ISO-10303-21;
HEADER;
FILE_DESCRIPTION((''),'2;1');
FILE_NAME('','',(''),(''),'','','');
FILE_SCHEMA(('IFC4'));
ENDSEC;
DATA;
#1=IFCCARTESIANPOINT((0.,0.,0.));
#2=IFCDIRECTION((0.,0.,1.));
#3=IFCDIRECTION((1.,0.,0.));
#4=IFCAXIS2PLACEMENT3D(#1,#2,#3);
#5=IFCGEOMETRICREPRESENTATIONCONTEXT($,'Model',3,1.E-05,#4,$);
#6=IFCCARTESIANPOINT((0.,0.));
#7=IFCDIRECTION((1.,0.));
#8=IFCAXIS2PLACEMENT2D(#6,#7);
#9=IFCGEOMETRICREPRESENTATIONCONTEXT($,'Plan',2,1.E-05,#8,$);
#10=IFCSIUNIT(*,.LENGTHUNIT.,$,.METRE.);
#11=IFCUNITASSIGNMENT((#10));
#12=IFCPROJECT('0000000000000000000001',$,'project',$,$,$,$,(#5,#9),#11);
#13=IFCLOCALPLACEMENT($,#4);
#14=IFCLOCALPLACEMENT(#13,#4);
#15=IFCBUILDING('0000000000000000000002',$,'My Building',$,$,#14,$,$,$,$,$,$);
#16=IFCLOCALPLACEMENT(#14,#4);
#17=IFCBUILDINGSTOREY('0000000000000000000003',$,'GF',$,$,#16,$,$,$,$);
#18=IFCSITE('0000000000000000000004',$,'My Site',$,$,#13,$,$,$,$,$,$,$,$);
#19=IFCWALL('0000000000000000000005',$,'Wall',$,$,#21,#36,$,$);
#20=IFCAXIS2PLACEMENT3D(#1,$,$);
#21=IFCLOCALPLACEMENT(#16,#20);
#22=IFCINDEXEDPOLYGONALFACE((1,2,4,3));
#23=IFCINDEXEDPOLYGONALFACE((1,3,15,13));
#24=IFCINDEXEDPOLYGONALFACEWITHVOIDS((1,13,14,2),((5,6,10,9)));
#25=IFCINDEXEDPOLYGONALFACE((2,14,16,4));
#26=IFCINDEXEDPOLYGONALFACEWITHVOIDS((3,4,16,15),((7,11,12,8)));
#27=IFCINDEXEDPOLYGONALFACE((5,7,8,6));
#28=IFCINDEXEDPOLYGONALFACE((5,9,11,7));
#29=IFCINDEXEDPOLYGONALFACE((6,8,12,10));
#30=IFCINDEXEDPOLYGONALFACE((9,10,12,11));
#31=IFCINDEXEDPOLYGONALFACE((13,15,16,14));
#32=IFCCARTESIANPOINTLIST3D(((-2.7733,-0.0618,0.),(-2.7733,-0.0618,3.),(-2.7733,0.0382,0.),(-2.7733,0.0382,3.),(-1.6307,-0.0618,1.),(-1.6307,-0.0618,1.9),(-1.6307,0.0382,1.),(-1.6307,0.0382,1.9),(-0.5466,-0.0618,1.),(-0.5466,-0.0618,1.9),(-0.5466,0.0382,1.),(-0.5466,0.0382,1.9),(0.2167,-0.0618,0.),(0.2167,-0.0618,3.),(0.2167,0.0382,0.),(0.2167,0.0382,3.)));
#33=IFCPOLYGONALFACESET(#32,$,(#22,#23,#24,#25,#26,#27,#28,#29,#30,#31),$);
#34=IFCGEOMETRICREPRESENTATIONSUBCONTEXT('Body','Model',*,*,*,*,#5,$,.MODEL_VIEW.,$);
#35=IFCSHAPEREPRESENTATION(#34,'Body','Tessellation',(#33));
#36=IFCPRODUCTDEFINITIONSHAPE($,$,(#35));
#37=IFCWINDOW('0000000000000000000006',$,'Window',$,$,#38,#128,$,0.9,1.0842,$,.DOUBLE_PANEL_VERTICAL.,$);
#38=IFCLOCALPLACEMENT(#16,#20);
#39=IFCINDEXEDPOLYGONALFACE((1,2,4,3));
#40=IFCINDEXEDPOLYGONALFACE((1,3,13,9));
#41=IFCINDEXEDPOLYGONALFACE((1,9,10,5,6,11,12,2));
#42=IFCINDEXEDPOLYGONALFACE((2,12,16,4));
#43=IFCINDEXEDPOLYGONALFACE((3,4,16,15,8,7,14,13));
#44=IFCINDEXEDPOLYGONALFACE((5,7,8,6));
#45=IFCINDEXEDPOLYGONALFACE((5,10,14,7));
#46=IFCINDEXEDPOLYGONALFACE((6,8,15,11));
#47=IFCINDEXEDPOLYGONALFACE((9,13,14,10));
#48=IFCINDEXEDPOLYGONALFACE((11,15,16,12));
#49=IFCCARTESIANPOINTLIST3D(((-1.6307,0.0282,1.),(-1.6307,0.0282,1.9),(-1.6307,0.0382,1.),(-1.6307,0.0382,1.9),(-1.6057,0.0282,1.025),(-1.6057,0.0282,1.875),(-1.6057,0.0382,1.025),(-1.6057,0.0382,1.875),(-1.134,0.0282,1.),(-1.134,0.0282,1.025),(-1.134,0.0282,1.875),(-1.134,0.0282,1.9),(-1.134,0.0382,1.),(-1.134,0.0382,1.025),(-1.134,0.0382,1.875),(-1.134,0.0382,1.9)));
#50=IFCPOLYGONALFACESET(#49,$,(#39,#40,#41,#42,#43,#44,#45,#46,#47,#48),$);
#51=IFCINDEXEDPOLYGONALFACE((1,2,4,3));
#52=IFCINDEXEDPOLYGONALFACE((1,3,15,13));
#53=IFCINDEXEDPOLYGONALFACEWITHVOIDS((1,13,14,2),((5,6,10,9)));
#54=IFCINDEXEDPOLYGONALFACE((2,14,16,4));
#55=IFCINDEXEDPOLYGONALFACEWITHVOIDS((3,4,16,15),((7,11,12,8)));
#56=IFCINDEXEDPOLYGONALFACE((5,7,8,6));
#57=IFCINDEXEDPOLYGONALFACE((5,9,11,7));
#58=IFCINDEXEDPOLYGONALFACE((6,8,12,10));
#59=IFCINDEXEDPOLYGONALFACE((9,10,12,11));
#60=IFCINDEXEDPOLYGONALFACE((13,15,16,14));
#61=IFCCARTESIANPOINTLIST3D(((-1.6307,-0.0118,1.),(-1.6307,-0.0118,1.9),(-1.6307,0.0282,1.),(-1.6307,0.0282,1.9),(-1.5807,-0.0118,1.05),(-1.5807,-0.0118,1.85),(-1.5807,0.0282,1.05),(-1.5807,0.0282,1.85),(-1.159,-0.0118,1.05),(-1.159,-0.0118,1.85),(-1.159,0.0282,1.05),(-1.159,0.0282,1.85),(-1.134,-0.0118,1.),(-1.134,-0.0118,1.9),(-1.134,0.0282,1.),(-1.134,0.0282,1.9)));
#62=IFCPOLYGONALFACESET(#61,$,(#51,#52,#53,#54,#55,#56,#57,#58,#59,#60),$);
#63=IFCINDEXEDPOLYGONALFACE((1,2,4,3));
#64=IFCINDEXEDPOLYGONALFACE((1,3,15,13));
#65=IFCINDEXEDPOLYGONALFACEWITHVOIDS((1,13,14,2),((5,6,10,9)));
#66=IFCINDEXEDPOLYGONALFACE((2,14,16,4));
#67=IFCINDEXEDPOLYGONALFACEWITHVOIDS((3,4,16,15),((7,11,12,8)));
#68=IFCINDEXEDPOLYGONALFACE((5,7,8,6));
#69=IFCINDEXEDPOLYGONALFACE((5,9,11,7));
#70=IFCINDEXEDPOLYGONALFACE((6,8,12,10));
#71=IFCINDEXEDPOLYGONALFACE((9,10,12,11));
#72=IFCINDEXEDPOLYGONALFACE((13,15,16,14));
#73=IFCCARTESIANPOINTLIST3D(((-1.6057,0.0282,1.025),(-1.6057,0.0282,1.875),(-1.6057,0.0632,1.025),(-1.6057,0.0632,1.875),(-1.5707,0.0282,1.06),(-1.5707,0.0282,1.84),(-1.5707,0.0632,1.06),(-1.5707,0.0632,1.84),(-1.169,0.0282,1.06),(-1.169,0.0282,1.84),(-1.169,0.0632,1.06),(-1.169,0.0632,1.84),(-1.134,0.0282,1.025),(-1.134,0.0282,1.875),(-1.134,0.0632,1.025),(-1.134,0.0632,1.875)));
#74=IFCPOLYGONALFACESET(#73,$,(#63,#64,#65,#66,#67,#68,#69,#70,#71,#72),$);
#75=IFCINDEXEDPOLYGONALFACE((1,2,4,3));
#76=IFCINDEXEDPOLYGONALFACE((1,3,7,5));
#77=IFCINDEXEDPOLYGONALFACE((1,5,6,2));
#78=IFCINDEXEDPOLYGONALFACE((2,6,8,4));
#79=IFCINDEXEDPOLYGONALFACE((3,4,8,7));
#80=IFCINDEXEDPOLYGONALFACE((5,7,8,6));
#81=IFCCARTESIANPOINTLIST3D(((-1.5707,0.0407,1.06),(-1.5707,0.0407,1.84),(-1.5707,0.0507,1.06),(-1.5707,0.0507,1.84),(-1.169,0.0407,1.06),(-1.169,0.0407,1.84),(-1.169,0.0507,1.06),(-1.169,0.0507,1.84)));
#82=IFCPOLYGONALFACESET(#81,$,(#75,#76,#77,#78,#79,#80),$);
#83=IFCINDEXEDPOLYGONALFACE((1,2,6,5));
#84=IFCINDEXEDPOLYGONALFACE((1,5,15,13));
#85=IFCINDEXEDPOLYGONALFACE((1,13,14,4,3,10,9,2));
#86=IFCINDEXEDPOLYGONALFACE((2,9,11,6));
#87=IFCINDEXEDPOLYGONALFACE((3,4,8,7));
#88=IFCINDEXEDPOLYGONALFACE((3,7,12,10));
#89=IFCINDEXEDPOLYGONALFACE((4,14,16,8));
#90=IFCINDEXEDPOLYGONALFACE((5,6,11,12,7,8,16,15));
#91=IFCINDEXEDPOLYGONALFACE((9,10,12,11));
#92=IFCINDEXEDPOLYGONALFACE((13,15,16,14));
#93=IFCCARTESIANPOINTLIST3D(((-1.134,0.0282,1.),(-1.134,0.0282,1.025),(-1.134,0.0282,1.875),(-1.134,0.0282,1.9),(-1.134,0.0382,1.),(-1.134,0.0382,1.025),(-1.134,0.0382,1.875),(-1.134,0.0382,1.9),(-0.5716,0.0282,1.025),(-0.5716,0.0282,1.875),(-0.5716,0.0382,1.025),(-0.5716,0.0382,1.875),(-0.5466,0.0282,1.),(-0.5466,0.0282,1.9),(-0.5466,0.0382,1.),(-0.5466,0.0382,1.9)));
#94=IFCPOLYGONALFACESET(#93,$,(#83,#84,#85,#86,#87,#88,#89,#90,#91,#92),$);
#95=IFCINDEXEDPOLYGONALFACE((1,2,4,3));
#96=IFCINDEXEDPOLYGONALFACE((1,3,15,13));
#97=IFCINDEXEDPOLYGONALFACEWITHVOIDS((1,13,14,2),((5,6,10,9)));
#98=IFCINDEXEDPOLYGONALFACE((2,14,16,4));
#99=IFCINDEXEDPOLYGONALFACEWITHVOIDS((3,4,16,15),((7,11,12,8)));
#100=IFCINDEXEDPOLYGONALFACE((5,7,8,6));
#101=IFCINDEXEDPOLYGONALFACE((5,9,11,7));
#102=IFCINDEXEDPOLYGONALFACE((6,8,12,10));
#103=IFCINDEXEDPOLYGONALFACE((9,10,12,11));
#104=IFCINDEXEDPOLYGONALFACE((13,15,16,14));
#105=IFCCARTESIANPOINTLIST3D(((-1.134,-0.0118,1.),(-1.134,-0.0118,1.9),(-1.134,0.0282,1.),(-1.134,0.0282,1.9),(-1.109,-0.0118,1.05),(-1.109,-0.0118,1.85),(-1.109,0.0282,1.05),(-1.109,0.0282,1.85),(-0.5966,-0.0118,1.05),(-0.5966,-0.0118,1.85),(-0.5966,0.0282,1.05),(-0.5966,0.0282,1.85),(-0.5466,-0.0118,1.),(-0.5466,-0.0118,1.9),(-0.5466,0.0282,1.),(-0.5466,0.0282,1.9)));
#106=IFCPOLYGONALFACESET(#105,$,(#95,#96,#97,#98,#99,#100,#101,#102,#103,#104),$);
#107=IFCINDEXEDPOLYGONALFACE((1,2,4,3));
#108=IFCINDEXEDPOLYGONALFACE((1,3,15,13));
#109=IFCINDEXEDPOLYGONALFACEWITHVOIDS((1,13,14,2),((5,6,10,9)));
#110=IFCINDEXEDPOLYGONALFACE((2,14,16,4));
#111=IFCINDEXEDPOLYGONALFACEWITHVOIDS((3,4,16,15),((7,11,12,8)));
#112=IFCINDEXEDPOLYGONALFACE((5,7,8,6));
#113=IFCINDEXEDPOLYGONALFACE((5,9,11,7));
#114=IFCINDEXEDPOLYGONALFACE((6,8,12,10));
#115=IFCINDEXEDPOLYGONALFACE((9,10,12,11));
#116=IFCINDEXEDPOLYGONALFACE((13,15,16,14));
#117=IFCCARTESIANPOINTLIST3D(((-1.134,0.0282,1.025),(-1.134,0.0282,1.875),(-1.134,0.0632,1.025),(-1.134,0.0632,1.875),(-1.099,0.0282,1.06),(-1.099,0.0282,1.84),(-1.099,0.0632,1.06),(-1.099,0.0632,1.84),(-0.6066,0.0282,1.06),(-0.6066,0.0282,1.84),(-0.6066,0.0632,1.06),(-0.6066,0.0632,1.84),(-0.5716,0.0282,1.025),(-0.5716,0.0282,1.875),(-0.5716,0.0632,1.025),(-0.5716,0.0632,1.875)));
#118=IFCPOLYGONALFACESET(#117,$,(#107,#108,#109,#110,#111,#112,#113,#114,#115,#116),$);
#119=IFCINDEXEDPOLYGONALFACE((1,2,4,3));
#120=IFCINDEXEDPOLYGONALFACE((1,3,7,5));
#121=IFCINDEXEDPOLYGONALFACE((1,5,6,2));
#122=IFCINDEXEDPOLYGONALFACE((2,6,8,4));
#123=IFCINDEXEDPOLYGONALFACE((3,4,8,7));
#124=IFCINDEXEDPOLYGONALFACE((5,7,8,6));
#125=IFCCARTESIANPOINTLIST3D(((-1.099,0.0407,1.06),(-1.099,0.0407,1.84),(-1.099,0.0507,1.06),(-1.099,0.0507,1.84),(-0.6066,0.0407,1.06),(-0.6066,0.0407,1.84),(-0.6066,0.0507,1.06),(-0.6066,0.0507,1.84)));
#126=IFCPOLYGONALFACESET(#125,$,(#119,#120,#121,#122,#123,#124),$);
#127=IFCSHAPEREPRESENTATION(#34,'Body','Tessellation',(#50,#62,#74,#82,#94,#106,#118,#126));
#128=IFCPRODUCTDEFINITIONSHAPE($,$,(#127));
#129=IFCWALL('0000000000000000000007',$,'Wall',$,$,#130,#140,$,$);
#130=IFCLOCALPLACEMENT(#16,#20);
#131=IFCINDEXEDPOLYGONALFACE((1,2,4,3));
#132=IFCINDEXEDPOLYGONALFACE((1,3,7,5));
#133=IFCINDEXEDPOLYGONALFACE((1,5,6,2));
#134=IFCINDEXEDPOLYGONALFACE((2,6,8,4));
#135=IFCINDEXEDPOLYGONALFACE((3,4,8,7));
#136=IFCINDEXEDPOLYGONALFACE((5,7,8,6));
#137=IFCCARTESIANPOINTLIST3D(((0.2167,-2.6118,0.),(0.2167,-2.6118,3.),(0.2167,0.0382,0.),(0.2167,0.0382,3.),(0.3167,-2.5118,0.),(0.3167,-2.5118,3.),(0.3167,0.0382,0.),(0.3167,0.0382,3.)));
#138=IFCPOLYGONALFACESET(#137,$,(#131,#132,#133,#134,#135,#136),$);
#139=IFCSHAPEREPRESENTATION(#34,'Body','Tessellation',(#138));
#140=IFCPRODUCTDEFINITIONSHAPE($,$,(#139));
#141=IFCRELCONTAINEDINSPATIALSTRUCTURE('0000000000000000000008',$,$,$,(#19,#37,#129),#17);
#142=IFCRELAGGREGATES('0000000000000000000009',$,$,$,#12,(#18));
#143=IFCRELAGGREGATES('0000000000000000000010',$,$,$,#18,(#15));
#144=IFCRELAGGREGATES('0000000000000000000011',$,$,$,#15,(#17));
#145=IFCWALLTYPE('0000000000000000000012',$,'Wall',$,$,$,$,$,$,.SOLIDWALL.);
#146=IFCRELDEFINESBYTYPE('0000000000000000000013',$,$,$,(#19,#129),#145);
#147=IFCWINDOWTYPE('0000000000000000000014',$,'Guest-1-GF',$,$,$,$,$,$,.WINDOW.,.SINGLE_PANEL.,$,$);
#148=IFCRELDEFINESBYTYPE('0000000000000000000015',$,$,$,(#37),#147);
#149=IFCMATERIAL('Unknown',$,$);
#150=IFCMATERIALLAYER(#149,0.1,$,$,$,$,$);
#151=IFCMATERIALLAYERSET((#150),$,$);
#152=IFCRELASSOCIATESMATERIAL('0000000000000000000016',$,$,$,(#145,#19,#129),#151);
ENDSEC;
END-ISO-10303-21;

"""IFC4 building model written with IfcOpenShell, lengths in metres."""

from ifc_helpers import new_model, entity, si_unit, frame, origin_with_axes, origin_2d_with_axis, place, context, subcontext, project, spatial, line, indexed_curve, outline, extrude, shape, source, transform, mapped, material, layer, layer_set, layer_usage, type_object, type_shapes, element, fill, save


model = new_model("IFC4")

# Units and contexts
model_context = context("Model", 3, precision=1e-05, world=origin_with_axes())
plan_context = context("Plan", 2, precision=1e-05, world=origin_2d_with_axis())
body_context_1 = subcontext(model_context, "Body", "Model", "MODEL_VIEW")
body_context_2 = subcontext(plan_context, "Body", "Plan", "PLAN_VIEW")
ifc_project = project(units=[si_unit("LENGTHUNIT", "METRE")], contexts=[model_context, plan_context])

# Site, building, storey
site_placement = place(None, origin_with_axes())
site = spatial("IfcSite", under=ifc_project, at=site_placement, Name="My Site")
building_placement = place(site_placement, origin_with_axes())
building = spatial("IfcBuilding", under=site, at=building_placement, Name="My Building")
storey_placement = place(building_placement, origin_with_axes())
storey = spatial("IfcBuildingStorey", under=building, at=storey_placement, Name="GF")

# Shared definitions
ifc_material_1 = material(Name="Unknown")

# Wall, opening, window
ifc_layer_1 = layer(ifc_material_1, 0.1)
ifc_layer_set_1 = layer_set([ifc_layer_1])
ifc_layer_usage_1 = layer_usage(ifc_layer_set_1, "AXIS2", "POSITIVE", 0.0)
wall_type = type_object("IfcWallType", Name="Wall", PredefinedType="SOLIDWALL", material=ifc_layer_set_1)
wall_1_placement = place(storey_placement, frame((0.2167, 0.0382, 0.0), z_axis=(0.0, 0.0, 1.0), x_axis=(-1.0, 0.0, 0.0)))
wall_1 = element("IfcWall", 1, at=wall_1_placement, inside=storey, type_object=wall_type, material=ifc_layer_usage_1, Name="Wall", context=body_context_1, shape_type="SweptSolid", body=[
    extrude(outline(indexed_curve([(0.0, 0.0), (0.0, 0.1), (2.99, 0.1), (2.99, 0.0)], segments=[line(1, 2, 3, 4, 1)])), origin_with_axes(), (0.0, 0.0, 1.0), 3.0),
])
shared_shape_1 = source(origin_with_axes(), body_context_1, "Body", "SweptSolid", [
    extrude(outline(indexed_curve([(0.0, 0.0), (1.0842, 0.0), (1.0842, 0.9), (0.0, 0.9)], segments=[line(1, 2, 3, 4, 1)])), frame((0.0, -0.6, 0.0), z_axis=(0.0, -1.0, 0.0), x_axis=(1.0, 0.0, 0.0)), (0.0, 0.0, -1.0), 1.2),
])
opening_1_placement = place(wall_1_placement, frame((1.8474, 0.1, 1.0), z_axis=(0.0, 0.0, 1.0), x_axis=(-1.0, 0.0, 0.0)))
opening_1 = element("IfcOpeningElement", 2, at=opening_1_placement, cuts=wall_1, PredefinedType="OPENING", context=body_context_1, shape_type="MappedRepresentation", body=[
    mapped(shared_shape_1, transform((0.0, 0.0, 0.0), x_axis=(1.0, 0.0, 0.0), y_axis=(0.0, 1.0, 0.0), z_axis=(0.0, 0.0, 1.0), scale=1.0)),
])
window_type_1 = type_object("IfcWindowType", Name="Guest-1-GF", PartitioningType="SINGLE_PANEL", PredefinedType="WINDOW")
shared_shape_2 = source(origin_with_axes(), body_context_1, "Body", "SweptSolid", [
    extrude(outline(indexed_curve([(0.4967, 0.0), (0.0, 0.0), (0.0, 0.9), (0.4967, 0.9), (0.4967, 0.875), (0.025, 0.875), (0.025, 0.025), (0.4967, 0.025)], segments=[line(1, 2, 3, 4, 5, 6, 7, 8, 1)])), frame((0.0, 0.09, 0.0), z_axis=(0.0, -1.0, 0.0), x_axis=(1.0, 0.0, 0.0)), (0.0, 0.0, -1.0), 0.01),
    extrude(outline(indexed_curve([(0.0, 0.0), (0.4967, 0.0), (0.4967, 0.9), (0.0, 0.9)], segments=[line(1, 2, 3, 4, 1)]), holes=[indexed_curve([(0.05, 0.05), (0.4717, 0.05), (0.4717, 0.85), (0.05, 0.85)], segments=[line(1, 2, 3, 4, 1)])]), frame((0.0, 0.05, 0.0), z_axis=(0.0, -1.0, 0.0), x_axis=(1.0, 0.0, 0.0)), (0.0, 0.0, -1.0), 0.04),
    extrude(outline(indexed_curve([(0.0, 0.0), (0.4717, 0.0), (0.4717, 0.85), (0.0, 0.85)], segments=[line(1, 2, 3, 4, 1)]), holes=[indexed_curve([(0.035, 0.035), (0.4367, 0.035), (0.4367, 0.815), (0.035, 0.815)], segments=[line(1, 2, 3, 4, 1)])]), frame((0.025, 0.09, 0.025), z_axis=(0.0, -1.0, 0.0), x_axis=(1.0, 0.0, 0.0)), (0.0, 0.0, -1.0), 0.035),
    extrude(outline(indexed_curve([(0.035, 0.035), (0.4367, 0.035), (0.4367, 0.815), (0.035, 0.815)], segments=[line(1, 2, 3, 4, 1)])), frame((0.025, 0.1025, 0.025), z_axis=(0.0, -1.0, 0.0), x_axis=(1.0, 0.0, 0.0)), (0.0, 0.0, -1.0), 0.01),
    extrude(outline(indexed_curve([(0.0, 0.9), (0.5874, 0.9), (0.5874, 0.0), (0.0, 0.0), (0.0, 0.025), (0.5624, 0.025), (0.5624, 0.875), (0.0, 0.875)], segments=[line(1, 2, 3, 4, 5, 6, 7, 8, 1)])), frame((0.4967, 0.09, 0.0), z_axis=(0.0, -1.0, 0.0), x_axis=(1.0, 0.0, 0.0)), (0.0, 0.0, -1.0), 0.01),
    extrude(outline(indexed_curve([(0.0, 0.0), (0.5874, 0.0), (0.5874, 0.9), (0.0, 0.9)], segments=[line(1, 2, 3, 4, 1)]), holes=[indexed_curve([(0.025, 0.05), (0.5374, 0.05), (0.5374, 0.85), (0.025, 0.85)], segments=[line(1, 2, 3, 4, 1)])]), frame((0.4967, 0.05, 0.0), z_axis=(0.0, -1.0, 0.0), x_axis=(1.0, 0.0, 0.0)), (0.0, 0.0, -1.0), 0.04),
    extrude(outline(indexed_curve([(0.0, 0.0), (0.5624, 0.0), (0.5624, 0.85), (0.0, 0.85)], segments=[line(1, 2, 3, 4, 1)]), holes=[indexed_curve([(0.035, 0.035), (0.5274, 0.035), (0.5274, 0.815), (0.035, 0.815)], segments=[line(1, 2, 3, 4, 1)])]), frame((0.4967, 0.09, 0.025), z_axis=(0.0, -1.0, 0.0), x_axis=(1.0, 0.0, 0.0)), (0.0, 0.0, -1.0), 0.035),
    extrude(outline(indexed_curve([(0.035, 0.035), (0.5274, 0.035), (0.5274, 0.815), (0.035, 0.815)], segments=[line(1, 2, 3, 4, 1)])), frame((0.4967, 0.1025, 0.025), z_axis=(0.0, -1.0, 0.0), x_axis=(1.0, 0.0, 0.0)), (0.0, 0.0, -1.0), 0.01),
])
shared_shape_3 = source(origin_with_axes(), body_context_2, "Body", "Curve2D", [
    entity("IfcIndexedPolyCurve", entity("IfcCartesianPointList2D", [[0.05, 0.05], [0.4717, 0.05]])),
    entity("IfcIndexedPolyCurve", entity("IfcCartesianPointList2D", [[0.0, 0.1], [0.025, 0.1], [0.025, 0.09], [0.05, 0.09], [0.05, 0.05], [0.0, 0.05]]), [entity("IfcLineIndex", [1, 2, 3, 4, 5, 6, 1])]),
    entity("IfcIndexedPolyCurve", entity("IfcCartesianPointList2D", [[0.4967, 0.1], [0.4967, 0.1], [0.4967, 0.09], [0.4717, 0.09], [0.4717, 0.05], [0.4967, 0.05]])),
    entity("IfcIndexedPolyCurve", entity("IfcCartesianPointList2D", [[0.025, 0.09], [0.06, 0.09], [0.06, 0.125], [0.025, 0.125]]), [entity("IfcLineIndex", [1, 2, 3, 4, 1])]),
    entity("IfcIndexedPolyCurve", entity("IfcCartesianPointList2D", [[0.4967, 0.09], [0.4617, 0.09], [0.4617, 0.125], [0.4967, 0.125]]), [entity("IfcLineIndex", [1, 2, 3, 4, 1])]),
    entity("IfcIndexedPolyCurve", entity("IfcCartesianPointList2D", [[0.06, 0.09], [0.4617, 0.09]])),
    entity("IfcIndexedPolyCurve", entity("IfcCartesianPointList2D", [[0.06, 0.125], [0.4617, 0.125]])),
    entity("IfcIndexedPolyCurve", entity("IfcCartesianPointList2D", [[0.06, 0.1075], [0.4617, 0.1075]])),
    entity("IfcIndexedPolyCurve", entity("IfcCartesianPointList2D", [[0.5217, 0.05], [1.0342, 0.05]])),
    entity("IfcIndexedPolyCurve", entity("IfcCartesianPointList2D", [[0.4967, 0.1], [0.4967, 0.1], [0.4967, 0.09], [0.5217, 0.09], [0.5217, 0.05], [0.4967, 0.05]])),
    entity("IfcIndexedPolyCurve", entity("IfcCartesianPointList2D", [[1.0842, 0.1], [1.0592, 0.1], [1.0592, 0.09], [1.0342, 0.09], [1.0342, 0.05], [1.0842, 0.05]]), [entity("IfcLineIndex", [1, 2, 3, 4, 5, 6, 1])]),
    entity("IfcIndexedPolyCurve", entity("IfcCartesianPointList2D", [[0.4967, 0.09], [0.5317, 0.09], [0.5317, 0.125], [0.4967, 0.125]]), [entity("IfcLineIndex", [1, 2, 3, 4, 1])]),
    entity("IfcIndexedPolyCurve", entity("IfcCartesianPointList2D", [[1.0592, 0.09], [1.0242, 0.09], [1.0242, 0.125], [1.0592, 0.125]]), [entity("IfcLineIndex", [1, 2, 3, 4, 1])]),
    entity("IfcIndexedPolyCurve", entity("IfcCartesianPointList2D", [[0.5317, 0.09], [1.0242, 0.09]])),
    entity("IfcIndexedPolyCurve", entity("IfcCartesianPointList2D", [[0.5317, 0.125], [1.0242, 0.125]])),
    entity("IfcIndexedPolyCurve", entity("IfcCartesianPointList2D", [[0.5317, 0.1075], [1.0242, 0.1075]])),
])
type_shapes(window_type_1, [shared_shape_2, shared_shape_3])
window_1_placement = place(opening_1_placement, frame((0.0, 0.0, 0.0), z_axis=(0.0, 0.0, 1.0), x_axis=(1.0, 0.0, 0.0)))
window_1 = element("IfcWindow", 3, at=window_1_placement, inside=storey, type_object=window_type_1, Name="Window", OverallHeight=0.9, OverallWidth=1.0842, PartitioningType="DOUBLE_PANEL_VERTICAL", shapes=[
    shape(body_context_1, "Body", "MappedRepresentation", [mapped(shared_shape_2, transform((0.0, 0.0, 0.0), x_axis=(1.0, 0.0, 0.0), y_axis=(0.0, 1.0, 0.0), z_axis=(0.0, 0.0, 1.0), scale=1.0))]),
    shape(body_context_2, "Body", "MappedRepresentation", [mapped(shared_shape_3, transform((0.0, 0.0, 0.0), x_axis=(1.0, 0.0, 0.0), y_axis=(0.0, 1.0, 0.0), z_axis=(0.0, 0.0, 1.0), scale=1.0))]),
])
fill(opening_1, window_1)

# Wall
ifc_layer_usage_2 = layer_usage(ifc_layer_set_1, "AXIS2", "POSITIVE", 0.0)
wall_2_placement = place(storey_placement, frame((0.2167, 0.0382, 0.0), z_axis=(0.0, 0.0, 1.0), x_axis=(0.0, -1.0, 0.0)))
element("IfcWall", 4, at=wall_2_placement, inside=storey, type_object=wall_type, material=ifc_layer_usage_2, Name="Wall", context=body_context_1, shape_type="SweptSolid", body=[
    extrude(outline(indexed_curve([(0.0, 0.0), (0.0, 0.1), (2.55, 0.1), (2.65, 0.0)], segments=[line(1, 2, 3, 4, 1)])), origin_with_axes(), (0.0, 0.0, 1.0), 3.0),
])

save(model, "model.ifc")
